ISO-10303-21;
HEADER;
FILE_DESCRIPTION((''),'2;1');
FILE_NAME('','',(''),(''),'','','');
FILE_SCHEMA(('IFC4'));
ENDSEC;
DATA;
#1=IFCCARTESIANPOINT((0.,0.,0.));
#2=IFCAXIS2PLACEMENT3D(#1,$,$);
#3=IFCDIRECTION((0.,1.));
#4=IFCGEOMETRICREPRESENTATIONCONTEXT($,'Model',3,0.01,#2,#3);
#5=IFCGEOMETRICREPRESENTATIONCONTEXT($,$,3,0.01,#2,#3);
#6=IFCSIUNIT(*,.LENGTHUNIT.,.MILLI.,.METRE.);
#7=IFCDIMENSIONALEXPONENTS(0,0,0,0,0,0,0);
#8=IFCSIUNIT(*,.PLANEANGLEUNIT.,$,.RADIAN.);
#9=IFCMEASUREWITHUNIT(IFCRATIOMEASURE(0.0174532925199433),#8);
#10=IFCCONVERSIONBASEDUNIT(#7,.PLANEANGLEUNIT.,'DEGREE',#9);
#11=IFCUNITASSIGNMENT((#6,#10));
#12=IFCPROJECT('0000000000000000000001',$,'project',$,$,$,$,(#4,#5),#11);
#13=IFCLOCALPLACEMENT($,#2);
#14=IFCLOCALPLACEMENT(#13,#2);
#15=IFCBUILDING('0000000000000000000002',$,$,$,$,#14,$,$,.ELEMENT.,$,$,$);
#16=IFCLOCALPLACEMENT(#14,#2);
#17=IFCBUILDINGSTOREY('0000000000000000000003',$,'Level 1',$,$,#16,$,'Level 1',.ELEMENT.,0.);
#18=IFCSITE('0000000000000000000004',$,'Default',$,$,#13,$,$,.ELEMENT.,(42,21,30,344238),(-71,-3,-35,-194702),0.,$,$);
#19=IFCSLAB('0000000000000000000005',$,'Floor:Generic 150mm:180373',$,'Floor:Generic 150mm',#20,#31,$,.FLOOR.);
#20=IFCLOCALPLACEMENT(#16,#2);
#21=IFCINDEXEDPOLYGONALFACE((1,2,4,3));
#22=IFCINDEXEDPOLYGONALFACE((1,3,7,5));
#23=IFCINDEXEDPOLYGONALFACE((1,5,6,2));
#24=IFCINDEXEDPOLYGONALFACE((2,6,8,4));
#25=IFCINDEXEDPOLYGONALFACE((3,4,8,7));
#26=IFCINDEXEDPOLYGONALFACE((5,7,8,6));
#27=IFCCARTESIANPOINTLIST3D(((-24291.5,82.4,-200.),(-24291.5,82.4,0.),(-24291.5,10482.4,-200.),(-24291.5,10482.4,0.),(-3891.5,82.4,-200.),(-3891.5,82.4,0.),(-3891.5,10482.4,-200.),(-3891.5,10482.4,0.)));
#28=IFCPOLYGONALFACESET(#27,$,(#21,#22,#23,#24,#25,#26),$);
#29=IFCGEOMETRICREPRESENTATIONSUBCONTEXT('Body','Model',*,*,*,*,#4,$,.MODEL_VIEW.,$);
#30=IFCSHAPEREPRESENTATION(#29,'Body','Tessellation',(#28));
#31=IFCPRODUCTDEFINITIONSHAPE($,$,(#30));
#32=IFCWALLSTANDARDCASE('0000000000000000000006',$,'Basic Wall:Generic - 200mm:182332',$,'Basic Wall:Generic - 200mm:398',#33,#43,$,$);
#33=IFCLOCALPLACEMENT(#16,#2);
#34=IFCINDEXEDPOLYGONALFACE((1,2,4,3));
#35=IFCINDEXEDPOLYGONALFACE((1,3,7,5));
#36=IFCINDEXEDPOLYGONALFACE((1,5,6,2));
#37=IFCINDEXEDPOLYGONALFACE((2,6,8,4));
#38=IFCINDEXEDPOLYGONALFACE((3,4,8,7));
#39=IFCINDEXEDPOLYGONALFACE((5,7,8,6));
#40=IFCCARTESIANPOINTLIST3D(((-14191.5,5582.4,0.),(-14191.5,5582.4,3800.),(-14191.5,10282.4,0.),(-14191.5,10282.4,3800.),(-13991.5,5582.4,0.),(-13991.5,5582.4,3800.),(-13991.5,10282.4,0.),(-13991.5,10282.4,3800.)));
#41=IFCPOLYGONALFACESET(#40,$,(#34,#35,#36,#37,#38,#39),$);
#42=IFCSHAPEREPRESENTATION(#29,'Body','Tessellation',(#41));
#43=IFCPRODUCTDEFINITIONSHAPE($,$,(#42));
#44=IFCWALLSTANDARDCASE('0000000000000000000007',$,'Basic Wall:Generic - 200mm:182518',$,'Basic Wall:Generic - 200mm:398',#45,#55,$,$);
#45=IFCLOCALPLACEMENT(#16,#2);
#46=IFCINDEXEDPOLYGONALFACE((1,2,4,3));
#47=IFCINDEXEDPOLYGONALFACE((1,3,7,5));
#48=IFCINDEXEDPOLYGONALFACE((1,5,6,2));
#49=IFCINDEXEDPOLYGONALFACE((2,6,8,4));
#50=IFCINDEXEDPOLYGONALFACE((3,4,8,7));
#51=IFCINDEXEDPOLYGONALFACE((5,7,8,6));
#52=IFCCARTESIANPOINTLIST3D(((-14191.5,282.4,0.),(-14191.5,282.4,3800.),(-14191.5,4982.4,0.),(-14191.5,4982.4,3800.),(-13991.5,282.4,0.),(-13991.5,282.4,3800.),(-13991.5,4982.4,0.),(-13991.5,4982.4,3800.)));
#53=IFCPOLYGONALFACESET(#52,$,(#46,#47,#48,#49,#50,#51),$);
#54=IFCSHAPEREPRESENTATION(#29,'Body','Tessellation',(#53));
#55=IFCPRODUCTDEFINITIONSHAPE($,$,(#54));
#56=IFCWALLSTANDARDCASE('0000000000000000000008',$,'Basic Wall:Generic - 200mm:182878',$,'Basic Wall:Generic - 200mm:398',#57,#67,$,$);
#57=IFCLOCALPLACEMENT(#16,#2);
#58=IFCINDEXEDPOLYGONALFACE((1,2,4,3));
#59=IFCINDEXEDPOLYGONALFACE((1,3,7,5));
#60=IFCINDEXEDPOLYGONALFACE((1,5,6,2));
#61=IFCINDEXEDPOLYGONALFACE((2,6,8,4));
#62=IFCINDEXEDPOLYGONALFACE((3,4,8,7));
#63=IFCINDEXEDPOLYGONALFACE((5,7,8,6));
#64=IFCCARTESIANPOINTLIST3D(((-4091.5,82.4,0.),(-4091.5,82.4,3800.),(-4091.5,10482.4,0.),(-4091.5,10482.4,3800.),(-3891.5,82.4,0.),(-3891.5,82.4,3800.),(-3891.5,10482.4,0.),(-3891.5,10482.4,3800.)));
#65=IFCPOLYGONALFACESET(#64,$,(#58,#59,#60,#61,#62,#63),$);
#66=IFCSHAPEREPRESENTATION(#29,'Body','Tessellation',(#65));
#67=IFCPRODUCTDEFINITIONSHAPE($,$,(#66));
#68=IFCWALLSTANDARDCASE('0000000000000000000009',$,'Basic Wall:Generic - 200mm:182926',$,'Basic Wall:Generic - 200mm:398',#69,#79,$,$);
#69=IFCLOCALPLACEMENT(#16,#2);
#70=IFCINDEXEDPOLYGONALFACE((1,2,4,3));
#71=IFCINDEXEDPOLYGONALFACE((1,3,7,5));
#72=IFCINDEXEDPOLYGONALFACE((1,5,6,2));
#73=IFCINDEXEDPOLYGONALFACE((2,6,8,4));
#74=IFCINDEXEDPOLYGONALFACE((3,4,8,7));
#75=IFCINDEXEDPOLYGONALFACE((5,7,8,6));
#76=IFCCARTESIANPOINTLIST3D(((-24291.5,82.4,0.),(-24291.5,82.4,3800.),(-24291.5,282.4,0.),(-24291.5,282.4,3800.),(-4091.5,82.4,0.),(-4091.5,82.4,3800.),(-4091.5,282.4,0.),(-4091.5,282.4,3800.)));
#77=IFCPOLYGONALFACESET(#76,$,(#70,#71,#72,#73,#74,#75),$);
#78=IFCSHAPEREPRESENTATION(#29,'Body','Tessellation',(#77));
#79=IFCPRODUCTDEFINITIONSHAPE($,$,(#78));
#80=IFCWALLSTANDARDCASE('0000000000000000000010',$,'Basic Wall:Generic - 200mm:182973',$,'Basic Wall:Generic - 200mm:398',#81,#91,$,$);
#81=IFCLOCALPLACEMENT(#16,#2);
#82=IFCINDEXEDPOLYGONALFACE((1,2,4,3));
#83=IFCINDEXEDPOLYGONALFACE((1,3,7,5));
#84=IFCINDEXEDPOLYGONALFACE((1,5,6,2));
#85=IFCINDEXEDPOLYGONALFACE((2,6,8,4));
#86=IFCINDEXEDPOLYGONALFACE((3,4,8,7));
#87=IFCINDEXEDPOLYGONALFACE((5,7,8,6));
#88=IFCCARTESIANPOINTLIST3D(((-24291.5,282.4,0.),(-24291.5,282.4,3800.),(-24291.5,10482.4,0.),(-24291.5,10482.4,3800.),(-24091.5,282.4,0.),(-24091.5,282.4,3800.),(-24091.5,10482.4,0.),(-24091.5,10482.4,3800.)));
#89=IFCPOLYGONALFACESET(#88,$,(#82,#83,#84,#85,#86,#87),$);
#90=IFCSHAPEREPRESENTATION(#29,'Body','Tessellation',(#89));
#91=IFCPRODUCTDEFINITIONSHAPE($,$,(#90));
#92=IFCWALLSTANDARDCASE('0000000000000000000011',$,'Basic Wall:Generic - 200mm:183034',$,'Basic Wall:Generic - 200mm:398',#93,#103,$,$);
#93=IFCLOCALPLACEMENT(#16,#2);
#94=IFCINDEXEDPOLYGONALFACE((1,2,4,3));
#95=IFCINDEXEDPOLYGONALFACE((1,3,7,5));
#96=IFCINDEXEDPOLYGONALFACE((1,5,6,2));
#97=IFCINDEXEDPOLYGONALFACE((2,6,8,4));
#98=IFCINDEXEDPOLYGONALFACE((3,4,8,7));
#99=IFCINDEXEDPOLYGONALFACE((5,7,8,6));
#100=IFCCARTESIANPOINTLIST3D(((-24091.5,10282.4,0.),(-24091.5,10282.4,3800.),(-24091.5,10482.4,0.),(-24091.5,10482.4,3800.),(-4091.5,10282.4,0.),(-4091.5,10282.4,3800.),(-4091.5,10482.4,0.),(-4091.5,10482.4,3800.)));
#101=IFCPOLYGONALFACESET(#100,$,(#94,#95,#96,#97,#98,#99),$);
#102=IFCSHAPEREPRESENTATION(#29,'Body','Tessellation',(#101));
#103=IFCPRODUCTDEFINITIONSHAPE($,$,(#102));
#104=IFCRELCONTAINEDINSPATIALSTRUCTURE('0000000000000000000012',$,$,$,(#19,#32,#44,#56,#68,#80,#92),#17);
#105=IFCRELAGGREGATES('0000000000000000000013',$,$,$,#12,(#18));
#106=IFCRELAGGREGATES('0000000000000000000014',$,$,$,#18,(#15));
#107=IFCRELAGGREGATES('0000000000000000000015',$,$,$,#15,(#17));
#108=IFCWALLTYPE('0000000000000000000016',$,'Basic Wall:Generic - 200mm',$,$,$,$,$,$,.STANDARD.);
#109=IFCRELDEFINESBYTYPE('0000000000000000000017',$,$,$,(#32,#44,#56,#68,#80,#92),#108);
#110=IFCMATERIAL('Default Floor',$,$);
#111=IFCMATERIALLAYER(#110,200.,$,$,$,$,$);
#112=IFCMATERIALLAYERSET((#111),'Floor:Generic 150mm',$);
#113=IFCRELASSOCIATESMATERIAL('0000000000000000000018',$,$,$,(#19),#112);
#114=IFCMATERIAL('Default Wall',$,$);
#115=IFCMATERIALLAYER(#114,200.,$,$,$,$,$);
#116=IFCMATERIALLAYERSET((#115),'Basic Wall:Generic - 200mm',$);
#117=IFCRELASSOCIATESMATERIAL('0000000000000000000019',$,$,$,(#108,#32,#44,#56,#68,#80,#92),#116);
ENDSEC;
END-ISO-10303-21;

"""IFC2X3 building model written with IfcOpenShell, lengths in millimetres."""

from ifc_helpers import new_model, entity, si_unit, converted_unit, direction, frame, frame_2d, origin, origin_2d_with_axis, place, context, subcontext, project, spatial, rectangle, extrude, material, layer, layer_set, layer_usage, type_object, element, save


model = new_model("IFC2X3")

# Units and contexts
model_context = context("Model", 3, precision=0.01, world=origin(), true_north=direction((0.0, 1.0)))
context_of_model = context(None, 3, precision=0.01, world=origin(), true_north=direction((0.0, 1.0)))
body_context = subcontext(model_context, "Body", "Model", "MODEL_VIEW")
ifc_project = project(units=[si_unit("LENGTHUNIT", "METRE", prefix="MILLI"), converted_unit("PLANEANGLEUNIT", "DEGREE", entity("IfcRatioMeasure", 0.0174532925199433), si_unit("PLANEANGLEUNIT", "RADIAN"), dimensions=[0, 0, 0, 0, 0, 0, 0])], contexts=[model_context, context_of_model])

# Site, building, storey
site_placement = place(None, origin())
site = spatial("IfcSite", under=ifc_project, at=site_placement, Name="Default", CompositionType="ELEMENT", RefLatitude=(42, 21, 30, 344238), RefLongitude=(-71, -3, -35, -194702), RefElevation=0.0)
building_placement = place(site_placement, origin())
building = spatial("IfcBuilding", under=site, at=building_placement, CompositionType="ELEMENT")
storey_placement = place(building_placement, origin())
storey = spatial("IfcBuildingStorey", under=building, at=storey_placement, Name="Level 1", LongName="Level 1", CompositionType="ELEMENT", Elevation=0.0)

# Shared definitions
ifc_material_1 = material(Name="Default Wall")

# Slab
ifc_material_2 = material(Name="Default Floor")
ifc_layer_1 = layer(ifc_material_2, 200.0)
ifc_layer_set_1 = layer_set([ifc_layer_1], Name="Floor:Generic 150mm")
ifc_layer_usage_1 = layer_usage(ifc_layer_set_1, "AXIS3", "POSITIVE", 0.0)
slab_placement = place(storey_placement, origin())
element("IfcSlab", 1, at=slab_placement, inside=storey, material=ifc_layer_usage_1, Name="Floor:Generic 150mm:180373", ObjectType="Floor:Generic 150mm", PredefinedType="FLOOR", context=body_context, shape_type="SweptSolid", body=[
    extrude(rectangle(XDim=10400.0, YDim=20400.0, at=origin_2d_with_axis()), frame((-14091.5, 5282.4, 0.0), z_axis=(0.0, 0.0, -1.0), x_axis=(0.0, 1.0, 0.0)), (0.0, 0.0, 1.0), 200.0),
])

# Walls
ifc_layer_2 = layer(ifc_material_1, 200.0)
ifc_layer_set_2 = layer_set([ifc_layer_2], Name="Basic Wall:Generic - 200mm")
ifc_layer_usage_2 = layer_usage(ifc_layer_set_2, "AXIS2", "NEGATIVE", 100.0)
wall_type = type_object("IfcWallType", Name="Basic Wall:Generic - 200mm", PredefinedType="STANDARD", material=ifc_layer_set_2)
wall_1_placement = place(storey_placement, frame((-14091.5, 10282.4, 0.0), z_axis=(0.0, 0.0, 1.0), x_axis=(0.0, -1.0, 0.0)))
element("IfcWallStandardCase", 2, at=wall_1_placement, inside=storey, type_object=wall_type, material=ifc_layer_usage_2, Name="Basic Wall:Generic - 200mm:182332", ObjectType="Basic Wall:Generic - 200mm:398", context=body_context, shape_type="SweptSolid", body=[
    extrude(rectangle(XDim=4700.0, YDim=200.0, at=frame_2d((2350.0, 0.0), x_axis=(-1.0, 0.0))), origin(), (0.0, 0.0, 1.0), 3800.0),
])
ifc_layer_usage_3 = layer_usage(ifc_layer_set_2, "AXIS2", "NEGATIVE", 100.0)
wall_2_placement = place(storey_placement, frame((-14091.5, 282.4, 0.0), z_axis=(0.0, 0.0, 1.0), x_axis=(0.0, 1.0, 0.0)))
element("IfcWallStandardCase", 3, at=wall_2_placement, inside=storey, type_object=wall_type, material=ifc_layer_usage_3, Name="Basic Wall:Generic - 200mm:182518", ObjectType="Basic Wall:Generic - 200mm:398", context=body_context, shape_type="SweptSolid", body=[
    extrude(rectangle(XDim=4700.0, YDim=200.0, at=frame_2d((2350.0, 0.0), x_axis=(-1.0, 0.0))), origin(), (0.0, 0.0, 1.0), 3800.0),
])
ifc_layer_usage_4 = layer_usage(ifc_layer_set_2, "AXIS2", "NEGATIVE", 100.0)
wall_3_placement = place(storey_placement, frame((-3991.5, 10482.4, 0.0), z_axis=(0.0, 0.0, 1.0), x_axis=(0.0, -1.0, 0.0)))
element("IfcWallStandardCase", 4, at=wall_3_placement, inside=storey, type_object=wall_type, material=ifc_layer_usage_4, Name="Basic Wall:Generic - 200mm:182878", ObjectType="Basic Wall:Generic - 200mm:398", context=body_context, shape_type="SweptSolid", body=[
    extrude(rectangle(XDim=10400.0, YDim=200.0, at=frame_2d((5200.0, 0.0), x_axis=(-1.0, 0.0))), origin(), (0.0, 0.0, 1.0), 3800.0),
])
ifc_layer_usage_5 = layer_usage(ifc_layer_set_2, "AXIS2", "NEGATIVE", 100.0)
wall_4_placement = place(storey_placement, frame((-4091.5, 182.4, 0.0), z_axis=(0.0, 0.0, 1.0), x_axis=(-1.0, 0.0, 0.0)))
element("IfcWallStandardCase", 5, at=wall_4_placement, inside=storey, type_object=wall_type, material=ifc_layer_usage_5, Name="Basic Wall:Generic - 200mm:182926", ObjectType="Basic Wall:Generic - 200mm:398", context=body_context, shape_type="SweptSolid", body=[
    extrude(rectangle(XDim=20200.0, YDim=200.0, at=frame_2d((10100.0, 0.0), x_axis=(-1.0, 0.0))), origin(), (0.0, 0.0, 1.0), 3800.0),
])
ifc_layer_usage_6 = layer_usage(ifc_layer_set_2, "AXIS2", "NEGATIVE", 100.0)
wall_5_placement = place(storey_placement, frame((-24191.5, 282.4, 0.0), z_axis=(0.0, 0.0, 1.0), x_axis=(0.0, 1.0, 0.0)))
element("IfcWallStandardCase", 6, at=wall_5_placement, inside=storey, type_object=wall_type, material=ifc_layer_usage_6, Name="Basic Wall:Generic - 200mm:182973", ObjectType="Basic Wall:Generic - 200mm:398", context=body_context, shape_type="SweptSolid", body=[
    extrude(rectangle(XDim=10200.0, YDim=200.0, at=frame_2d((5100.0, 0.0), x_axis=(-1.0, 0.0))), origin(), (0.0, 0.0, 1.0), 3800.0),
])
ifc_layer_usage_7 = layer_usage(ifc_layer_set_2, "AXIS2", "NEGATIVE", 100.0)
wall_6_placement = place(storey_placement, frame((-24091.5, 10382.4, 0.0)))
element("IfcWallStandardCase", 7, at=wall_6_placement, inside=storey, type_object=wall_type, material=ifc_layer_usage_7, Name="Basic Wall:Generic - 200mm:183034", ObjectType="Basic Wall:Generic - 200mm:398", context=body_context, shape_type="SweptSolid", body=[
    extrude(rectangle(XDim=20000.0, YDim=200.0, at=frame_2d((10000.0, 0.0), x_axis=(-1.0, 0.0))), origin(), (0.0, 0.0, 1.0), 3800.0),
])

save(model, "model.ifc")
